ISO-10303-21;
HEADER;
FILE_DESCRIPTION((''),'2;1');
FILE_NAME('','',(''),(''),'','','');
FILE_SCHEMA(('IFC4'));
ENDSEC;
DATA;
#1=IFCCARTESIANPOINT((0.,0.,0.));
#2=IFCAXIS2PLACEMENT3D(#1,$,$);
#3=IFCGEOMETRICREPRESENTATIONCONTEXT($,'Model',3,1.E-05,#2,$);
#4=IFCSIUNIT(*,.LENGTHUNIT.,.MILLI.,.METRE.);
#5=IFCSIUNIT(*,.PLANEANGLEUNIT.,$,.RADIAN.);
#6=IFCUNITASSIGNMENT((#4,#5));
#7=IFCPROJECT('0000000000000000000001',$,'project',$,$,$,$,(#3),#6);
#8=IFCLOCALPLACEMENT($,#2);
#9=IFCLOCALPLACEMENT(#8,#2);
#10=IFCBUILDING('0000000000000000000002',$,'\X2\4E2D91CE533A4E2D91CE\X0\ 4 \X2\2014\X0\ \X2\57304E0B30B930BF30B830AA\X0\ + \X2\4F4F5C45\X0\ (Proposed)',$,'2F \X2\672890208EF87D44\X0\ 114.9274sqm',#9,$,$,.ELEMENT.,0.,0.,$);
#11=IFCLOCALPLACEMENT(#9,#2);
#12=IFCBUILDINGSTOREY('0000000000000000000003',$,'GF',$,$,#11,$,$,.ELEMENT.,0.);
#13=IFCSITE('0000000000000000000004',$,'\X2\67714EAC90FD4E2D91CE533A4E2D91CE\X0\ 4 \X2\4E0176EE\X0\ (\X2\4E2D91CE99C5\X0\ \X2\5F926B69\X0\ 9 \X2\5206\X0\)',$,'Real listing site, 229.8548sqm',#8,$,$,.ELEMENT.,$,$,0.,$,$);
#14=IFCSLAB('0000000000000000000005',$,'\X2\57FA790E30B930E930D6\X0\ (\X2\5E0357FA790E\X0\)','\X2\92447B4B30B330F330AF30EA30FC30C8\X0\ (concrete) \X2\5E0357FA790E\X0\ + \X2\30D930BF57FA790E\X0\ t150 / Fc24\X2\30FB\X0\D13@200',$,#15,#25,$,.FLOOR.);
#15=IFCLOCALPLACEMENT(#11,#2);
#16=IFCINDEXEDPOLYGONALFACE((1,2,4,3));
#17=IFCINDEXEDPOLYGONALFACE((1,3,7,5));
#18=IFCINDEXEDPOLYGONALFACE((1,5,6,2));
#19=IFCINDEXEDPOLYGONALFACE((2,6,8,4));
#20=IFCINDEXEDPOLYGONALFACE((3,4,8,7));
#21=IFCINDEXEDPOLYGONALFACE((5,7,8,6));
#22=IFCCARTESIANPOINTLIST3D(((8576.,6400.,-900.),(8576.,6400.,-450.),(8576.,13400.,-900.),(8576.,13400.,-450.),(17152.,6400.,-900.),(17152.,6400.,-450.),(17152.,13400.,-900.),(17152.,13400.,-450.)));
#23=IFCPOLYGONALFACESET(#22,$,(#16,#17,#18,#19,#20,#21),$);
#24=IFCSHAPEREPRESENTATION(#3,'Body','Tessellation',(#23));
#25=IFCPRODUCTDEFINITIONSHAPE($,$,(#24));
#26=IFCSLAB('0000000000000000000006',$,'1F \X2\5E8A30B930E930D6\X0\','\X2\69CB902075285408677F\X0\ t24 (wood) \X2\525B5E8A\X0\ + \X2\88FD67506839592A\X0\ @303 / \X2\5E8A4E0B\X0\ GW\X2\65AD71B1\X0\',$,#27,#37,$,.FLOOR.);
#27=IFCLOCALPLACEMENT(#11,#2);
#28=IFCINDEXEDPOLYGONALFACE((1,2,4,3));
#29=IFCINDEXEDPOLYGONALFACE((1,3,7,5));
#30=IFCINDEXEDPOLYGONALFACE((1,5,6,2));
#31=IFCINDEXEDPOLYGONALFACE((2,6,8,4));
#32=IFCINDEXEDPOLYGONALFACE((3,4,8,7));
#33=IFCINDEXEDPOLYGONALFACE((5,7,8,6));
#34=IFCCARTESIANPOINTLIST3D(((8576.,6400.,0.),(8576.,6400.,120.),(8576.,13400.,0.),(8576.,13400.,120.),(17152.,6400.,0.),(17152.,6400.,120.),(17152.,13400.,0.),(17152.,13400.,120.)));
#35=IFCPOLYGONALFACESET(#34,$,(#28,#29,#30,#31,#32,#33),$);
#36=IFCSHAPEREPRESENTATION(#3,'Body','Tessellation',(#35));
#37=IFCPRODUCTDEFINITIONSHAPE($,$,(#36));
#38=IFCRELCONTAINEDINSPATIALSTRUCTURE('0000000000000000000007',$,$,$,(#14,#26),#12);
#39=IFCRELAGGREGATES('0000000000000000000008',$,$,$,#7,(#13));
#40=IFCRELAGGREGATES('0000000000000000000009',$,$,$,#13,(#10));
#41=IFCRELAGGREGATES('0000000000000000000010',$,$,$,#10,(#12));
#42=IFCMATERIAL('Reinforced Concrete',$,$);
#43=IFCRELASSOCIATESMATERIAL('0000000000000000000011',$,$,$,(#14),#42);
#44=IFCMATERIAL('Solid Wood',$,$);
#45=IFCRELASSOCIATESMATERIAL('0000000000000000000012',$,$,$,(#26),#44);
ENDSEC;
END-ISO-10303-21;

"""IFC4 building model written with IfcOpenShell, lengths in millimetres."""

from ifc_helpers import new_model, si_unit, frame, frame_2d, origin, place, context, project, spatial, rectangle, extrude, material, element, save


model = new_model("IFC4")

# Units and contexts
model_context = context("Model", 3, precision=1e-05, world=origin())
ifc_project = project(units=[si_unit("LENGTHUNIT", "METRE", prefix="MILLI"), si_unit("PLANEANGLEUNIT", "RADIAN")], contexts=[model_context])

# Site, building, storey
site_placement = place(None, origin())
site = spatial("IfcSite", under=ifc_project, at=site_placement, Name="東京都中野区中野 4 丁目 (中野駅 徒歩 9 分)", ObjectType="Real listing site, 229.8548sqm", CompositionType="ELEMENT", RefElevation=0.0)
building_placement = place(site_placement, origin())
building = spatial("IfcBuilding", under=site, at=building_placement, Name="中野区中野 4 — 地下スタジオ + 住居 (Proposed)", ObjectType="2F 木造軸組 114.9274sqm", CompositionType="ELEMENT", ElevationOfRefHeight=0.0, ElevationOfTerrain=0.0)
storey_placement = place(building_placement, origin())
storey = spatial("IfcBuildingStorey", under=building, at=storey_placement, Name="GF", CompositionType="ELEMENT", Elevation=0.0)

# Slabs
ifc_material_1 = material(Name="Reinforced Concrete")
slab_1_placement = place(storey_placement, frame((4288.0, 3200.0, -450.0)))
element("IfcSlab", 1, at=slab_1_placement, inside=storey, material=ifc_material_1, Name="基礎スラブ (布基礎)", Description="鉄筋コンクリート (concrete) 布基礎 + ベタ基礎 t150 / Fc24・D13@200", PredefinedType="FLOOR", context=model_context, shape_type="SweptSolid", body=[
    extrude(rectangle(XDim=8576.0, YDim=7000.0, at=frame_2d((4288.0, 3500.0))), frame((4288.0, 3200.0, -450.0)), (0.0, 0.0, 1.0), 450.0),
])
ifc_material_2 = material(Name="Solid Wood")
slab_2_placement = place(storey_placement, frame((4288.0, 3200.0, 0.0)))
element("IfcSlab", 2, at=slab_2_placement, inside=storey, material=ifc_material_2, Name="1F 床スラブ", Description="構造用合板 t24 (wood) 剛床 + 製材根太 @303 / 床下 GW断熱", PredefinedType="FLOOR", context=model_context, shape_type="SweptSolid", body=[
    extrude(rectangle(XDim=8576.0, YDim=7000.0, at=frame_2d((4288.0, 3500.0))), frame((4288.0, 3200.0, 0.0)), (0.0, 0.0, 1.0), 120.0),
])

save(model, "model.ifc")
